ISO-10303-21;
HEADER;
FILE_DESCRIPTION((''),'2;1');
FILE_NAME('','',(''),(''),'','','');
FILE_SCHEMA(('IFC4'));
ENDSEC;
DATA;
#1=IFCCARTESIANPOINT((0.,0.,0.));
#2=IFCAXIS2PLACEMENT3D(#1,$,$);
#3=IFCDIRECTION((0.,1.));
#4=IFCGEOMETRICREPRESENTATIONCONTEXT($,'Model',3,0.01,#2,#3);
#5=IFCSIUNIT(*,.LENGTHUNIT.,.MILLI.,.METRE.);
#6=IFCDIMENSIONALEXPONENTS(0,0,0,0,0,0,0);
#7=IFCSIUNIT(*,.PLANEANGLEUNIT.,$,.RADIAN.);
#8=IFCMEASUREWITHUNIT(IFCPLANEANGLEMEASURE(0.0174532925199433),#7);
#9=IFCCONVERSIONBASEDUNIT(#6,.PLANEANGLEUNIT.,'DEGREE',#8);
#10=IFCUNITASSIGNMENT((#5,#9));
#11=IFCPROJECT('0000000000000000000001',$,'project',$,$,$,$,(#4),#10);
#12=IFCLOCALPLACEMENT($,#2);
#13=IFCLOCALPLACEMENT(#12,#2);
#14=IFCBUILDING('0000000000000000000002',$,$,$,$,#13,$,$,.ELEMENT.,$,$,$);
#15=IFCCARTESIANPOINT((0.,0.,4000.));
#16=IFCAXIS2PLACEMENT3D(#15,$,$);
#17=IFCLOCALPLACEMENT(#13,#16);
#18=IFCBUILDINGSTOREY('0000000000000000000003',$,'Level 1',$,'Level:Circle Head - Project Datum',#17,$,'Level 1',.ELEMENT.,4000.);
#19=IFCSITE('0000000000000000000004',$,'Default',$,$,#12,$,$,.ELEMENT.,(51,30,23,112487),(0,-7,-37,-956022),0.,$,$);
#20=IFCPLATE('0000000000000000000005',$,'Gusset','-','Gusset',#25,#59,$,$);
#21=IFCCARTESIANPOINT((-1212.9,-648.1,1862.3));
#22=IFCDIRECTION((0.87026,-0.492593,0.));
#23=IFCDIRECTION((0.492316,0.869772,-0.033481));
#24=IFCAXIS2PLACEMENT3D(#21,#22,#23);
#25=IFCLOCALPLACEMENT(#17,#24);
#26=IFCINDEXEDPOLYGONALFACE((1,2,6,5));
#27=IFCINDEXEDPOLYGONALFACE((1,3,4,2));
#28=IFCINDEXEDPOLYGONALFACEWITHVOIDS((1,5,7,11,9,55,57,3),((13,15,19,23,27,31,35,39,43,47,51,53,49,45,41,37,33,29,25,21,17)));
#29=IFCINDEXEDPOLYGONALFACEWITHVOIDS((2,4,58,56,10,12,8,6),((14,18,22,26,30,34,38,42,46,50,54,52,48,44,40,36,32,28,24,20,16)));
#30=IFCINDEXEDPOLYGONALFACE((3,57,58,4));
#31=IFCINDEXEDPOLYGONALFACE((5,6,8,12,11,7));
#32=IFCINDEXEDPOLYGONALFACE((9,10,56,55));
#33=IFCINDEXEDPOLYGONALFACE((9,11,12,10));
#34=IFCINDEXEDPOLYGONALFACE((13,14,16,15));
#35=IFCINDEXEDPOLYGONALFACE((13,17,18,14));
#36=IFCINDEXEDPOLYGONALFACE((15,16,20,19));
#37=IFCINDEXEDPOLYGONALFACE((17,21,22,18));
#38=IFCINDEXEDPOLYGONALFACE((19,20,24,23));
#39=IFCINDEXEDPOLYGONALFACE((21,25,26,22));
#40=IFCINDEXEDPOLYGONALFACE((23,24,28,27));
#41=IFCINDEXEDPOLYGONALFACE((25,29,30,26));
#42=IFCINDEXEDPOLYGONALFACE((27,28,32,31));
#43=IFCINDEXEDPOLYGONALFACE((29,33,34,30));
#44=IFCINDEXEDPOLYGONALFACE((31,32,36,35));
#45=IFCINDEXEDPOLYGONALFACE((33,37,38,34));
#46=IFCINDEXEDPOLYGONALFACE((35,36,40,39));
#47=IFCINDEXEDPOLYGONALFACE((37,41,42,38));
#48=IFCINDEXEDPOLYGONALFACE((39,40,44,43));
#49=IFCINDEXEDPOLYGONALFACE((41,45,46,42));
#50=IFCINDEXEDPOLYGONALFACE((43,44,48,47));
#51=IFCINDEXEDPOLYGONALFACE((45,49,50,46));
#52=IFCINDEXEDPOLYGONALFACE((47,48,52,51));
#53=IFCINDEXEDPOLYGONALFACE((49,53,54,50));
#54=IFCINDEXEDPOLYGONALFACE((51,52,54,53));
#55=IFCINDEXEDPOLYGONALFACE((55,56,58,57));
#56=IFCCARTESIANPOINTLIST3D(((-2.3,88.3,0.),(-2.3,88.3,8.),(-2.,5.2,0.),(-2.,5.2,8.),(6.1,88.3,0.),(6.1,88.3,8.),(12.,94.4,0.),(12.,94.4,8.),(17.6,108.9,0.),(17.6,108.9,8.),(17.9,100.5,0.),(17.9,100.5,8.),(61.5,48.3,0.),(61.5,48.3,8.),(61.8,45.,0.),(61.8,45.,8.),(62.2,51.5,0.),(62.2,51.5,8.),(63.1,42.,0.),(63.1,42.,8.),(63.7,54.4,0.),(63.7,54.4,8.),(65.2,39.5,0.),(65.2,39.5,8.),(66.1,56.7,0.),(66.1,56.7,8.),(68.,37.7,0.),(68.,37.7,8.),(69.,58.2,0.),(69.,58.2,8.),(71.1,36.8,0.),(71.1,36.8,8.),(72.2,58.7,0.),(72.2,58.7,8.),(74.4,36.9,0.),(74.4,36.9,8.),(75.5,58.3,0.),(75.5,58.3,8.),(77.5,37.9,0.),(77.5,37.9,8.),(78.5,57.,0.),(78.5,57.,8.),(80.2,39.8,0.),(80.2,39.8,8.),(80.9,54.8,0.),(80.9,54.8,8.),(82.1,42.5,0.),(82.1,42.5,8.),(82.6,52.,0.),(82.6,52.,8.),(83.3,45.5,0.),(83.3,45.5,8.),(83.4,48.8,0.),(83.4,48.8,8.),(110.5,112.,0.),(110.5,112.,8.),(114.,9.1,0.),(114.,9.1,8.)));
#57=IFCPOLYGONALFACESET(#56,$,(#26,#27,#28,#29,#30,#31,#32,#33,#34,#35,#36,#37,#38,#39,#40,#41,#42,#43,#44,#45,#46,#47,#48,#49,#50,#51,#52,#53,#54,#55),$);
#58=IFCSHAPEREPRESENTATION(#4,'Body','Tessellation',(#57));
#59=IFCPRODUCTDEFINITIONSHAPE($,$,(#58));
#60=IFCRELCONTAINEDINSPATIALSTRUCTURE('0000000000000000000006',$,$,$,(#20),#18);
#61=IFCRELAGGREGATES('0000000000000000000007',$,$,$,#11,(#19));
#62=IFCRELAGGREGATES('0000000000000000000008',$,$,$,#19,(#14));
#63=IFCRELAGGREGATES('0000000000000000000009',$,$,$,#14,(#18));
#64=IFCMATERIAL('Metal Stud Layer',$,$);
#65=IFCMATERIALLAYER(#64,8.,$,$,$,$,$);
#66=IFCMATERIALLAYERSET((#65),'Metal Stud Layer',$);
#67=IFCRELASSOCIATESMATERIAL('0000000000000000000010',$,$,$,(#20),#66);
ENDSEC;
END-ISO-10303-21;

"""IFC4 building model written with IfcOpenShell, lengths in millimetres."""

from ifc_helpers import new_model, entity, si_unit, converted_unit, point, direction, frame, frame_2d, origin, origin_with_axes, origin_2d_with_axis, place, context, project, spatial, polyline, circle_curve, line_curve, trimmed, segment, composite_curve, circle, outline, extrude, material, layer, layer_set, element, save


model = new_model("IFC4")

# Units and contexts
model_context = context("Model", 3, precision=0.01, world=origin(), true_north=direction((0.0, 1.0)))
ifc_project = project(units=[si_unit("LENGTHUNIT", "METRE", prefix="MILLI"), converted_unit("PLANEANGLEUNIT", "DEGREE", entity("IfcPlaneAngleMeasure", 0.0174532925199433), si_unit("PLANEANGLEUNIT", "RADIAN"), dimensions=[0, 0, 0, 0, 0, 0, 0])], contexts=[model_context])

# Site, building, storey
site_placement = place(None, origin())
site = spatial("IfcSite", under=ifc_project, at=site_placement, Name="Default", CompositionType="ELEMENT", RefLatitude=(51, 30, 23, 112487), RefLongitude=(0, -7, -37, -956022), RefElevation=0.0)
building_placement = place(site_placement, origin())
building = spatial("IfcBuilding", under=site, at=building_placement, CompositionType="ELEMENT")
storey_placement = place(building_placement, frame((0.0, 0.0, 4000.0)))
storey = spatial("IfcBuildingStorey", under=building, at=storey_placement, Name="Level 1", ObjectType="Level:Circle Head - Project Datum", LongName="Level 1", CompositionType="ELEMENT", Elevation=4000.0)

# Plate, openings
ifc_material_1 = material(Name="Metal Stud Layer")
ifc_layer_1 = layer(ifc_material_1, 8.0)
ifc_layer_set_1 = layer_set([ifc_layer_1], Name="Metal Stud Layer")
plate_1_placement = place(storey_placement, frame((-1212.9, -648.1, 1862.3), z_axis=(0.87026, -0.492593, 0.0), x_axis=(0.492316, 0.869772, -0.033481)))
plate_1 = element("IfcPlate", 1, at=plate_1_placement, inside=storey, material=ifc_layer_set_1, Name="Gusset", Description="-", ObjectType="Gusset", context=model_context, shape_type="SweptSolid", body=[
    extrude(outline(polyline([(114.0, 9.1), (110.5, 112.0), (17.6, 108.9), (17.9, 100.5), (6.1, 88.3), (-2.3, 88.3), (-2.0, 5.2), (114.0, 9.1)])), origin_with_axes(), (0.0, 0.0, 1.0), 8.0),
])
opening_1_placement = place(plate_1_placement, origin_with_axes())
element("IfcOpeningElement", 2, at=opening_1_placement, cuts=plate_1, ObjectType="Opening", context=model_context, shape_type="SweptSolid", body=[
    extrude(outline(composite_curve([segment(trimmed(line_curve((17.9, 100.5), (-0.693597, -0.720363), 8.455359), [point((17.9, 100.5))], [point((12.0, 94.4))], True, "CARTESIAN"), True, "CONTINUOUS"), segment(trimmed(circle_curve(frame_2d((-2.4, 108.3), x_axis=(1.0, 0.0)), 20.0), [point((12.0, 94.4))], [point((17.6, 108.9))], True, "CARTESIAN"), True, "CONTINUOUS"), segment(trimmed(line_curve((17.6, 108.9), (0.033481, -0.999439), 8.455359), [point((17.6, 108.9))], [point((17.9, 100.5))], True, "CARTESIAN"), True, "CONTINUOUS")], self_intersect="UNKNOWN")), origin(), (0.0, 0.0, 1.0), 8.0),
])
opening_2_placement = place(plate_1_placement, origin_with_axes())
element("IfcOpeningElement", 3, at=opening_2_placement, cuts=plate_1, ObjectType="Opening", context=model_context, shape_type="SweptSolid", body=[
    extrude(outline(composite_curve([segment(trimmed(line_curve((6.1, 88.3), (-0.99999, -0.004369), 8.455359), [point((6.1, 88.3))], [point((-2.3, 88.3))], True, "CARTESIAN"), True, "CONTINUOUS"), segment(trimmed(circle_curve(frame_2d((-2.4, 108.3), x_axis=(1.0, 0.0)), 20.0), [point((-2.3, 88.3))], [point((12.0, 94.4))], True, "CARTESIAN"), True, "CONTINUOUS"), segment(trimmed(line_curve((12.0, 94.4), (-0.693597, -0.720363), 8.455359), [point((12.0, 94.4))], [point((6.1, 88.3))], True, "CARTESIAN"), True, "CONTINUOUS")], self_intersect="UNKNOWN")), origin(), (0.0, 0.0, 1.0), 8.0),
])
opening_3_placement = place(plate_1_placement, frame((72.5, 47.7, -0.5), z_axis=(0.0, 0.0, 1.0), x_axis=(0.877396, -0.479766, 0.0)))
element("IfcOpeningElement", 4, at=opening_3_placement, cuts=plate_1, ObjectType="Opening", context=model_context, shape_type="SweptSolid", body=[
    extrude(circle(Radius=11.0, at=origin_2d_with_axis()), origin(), (0.0, 0.0, 1.0), 9.0),
])

save(model, "model.ifc")
